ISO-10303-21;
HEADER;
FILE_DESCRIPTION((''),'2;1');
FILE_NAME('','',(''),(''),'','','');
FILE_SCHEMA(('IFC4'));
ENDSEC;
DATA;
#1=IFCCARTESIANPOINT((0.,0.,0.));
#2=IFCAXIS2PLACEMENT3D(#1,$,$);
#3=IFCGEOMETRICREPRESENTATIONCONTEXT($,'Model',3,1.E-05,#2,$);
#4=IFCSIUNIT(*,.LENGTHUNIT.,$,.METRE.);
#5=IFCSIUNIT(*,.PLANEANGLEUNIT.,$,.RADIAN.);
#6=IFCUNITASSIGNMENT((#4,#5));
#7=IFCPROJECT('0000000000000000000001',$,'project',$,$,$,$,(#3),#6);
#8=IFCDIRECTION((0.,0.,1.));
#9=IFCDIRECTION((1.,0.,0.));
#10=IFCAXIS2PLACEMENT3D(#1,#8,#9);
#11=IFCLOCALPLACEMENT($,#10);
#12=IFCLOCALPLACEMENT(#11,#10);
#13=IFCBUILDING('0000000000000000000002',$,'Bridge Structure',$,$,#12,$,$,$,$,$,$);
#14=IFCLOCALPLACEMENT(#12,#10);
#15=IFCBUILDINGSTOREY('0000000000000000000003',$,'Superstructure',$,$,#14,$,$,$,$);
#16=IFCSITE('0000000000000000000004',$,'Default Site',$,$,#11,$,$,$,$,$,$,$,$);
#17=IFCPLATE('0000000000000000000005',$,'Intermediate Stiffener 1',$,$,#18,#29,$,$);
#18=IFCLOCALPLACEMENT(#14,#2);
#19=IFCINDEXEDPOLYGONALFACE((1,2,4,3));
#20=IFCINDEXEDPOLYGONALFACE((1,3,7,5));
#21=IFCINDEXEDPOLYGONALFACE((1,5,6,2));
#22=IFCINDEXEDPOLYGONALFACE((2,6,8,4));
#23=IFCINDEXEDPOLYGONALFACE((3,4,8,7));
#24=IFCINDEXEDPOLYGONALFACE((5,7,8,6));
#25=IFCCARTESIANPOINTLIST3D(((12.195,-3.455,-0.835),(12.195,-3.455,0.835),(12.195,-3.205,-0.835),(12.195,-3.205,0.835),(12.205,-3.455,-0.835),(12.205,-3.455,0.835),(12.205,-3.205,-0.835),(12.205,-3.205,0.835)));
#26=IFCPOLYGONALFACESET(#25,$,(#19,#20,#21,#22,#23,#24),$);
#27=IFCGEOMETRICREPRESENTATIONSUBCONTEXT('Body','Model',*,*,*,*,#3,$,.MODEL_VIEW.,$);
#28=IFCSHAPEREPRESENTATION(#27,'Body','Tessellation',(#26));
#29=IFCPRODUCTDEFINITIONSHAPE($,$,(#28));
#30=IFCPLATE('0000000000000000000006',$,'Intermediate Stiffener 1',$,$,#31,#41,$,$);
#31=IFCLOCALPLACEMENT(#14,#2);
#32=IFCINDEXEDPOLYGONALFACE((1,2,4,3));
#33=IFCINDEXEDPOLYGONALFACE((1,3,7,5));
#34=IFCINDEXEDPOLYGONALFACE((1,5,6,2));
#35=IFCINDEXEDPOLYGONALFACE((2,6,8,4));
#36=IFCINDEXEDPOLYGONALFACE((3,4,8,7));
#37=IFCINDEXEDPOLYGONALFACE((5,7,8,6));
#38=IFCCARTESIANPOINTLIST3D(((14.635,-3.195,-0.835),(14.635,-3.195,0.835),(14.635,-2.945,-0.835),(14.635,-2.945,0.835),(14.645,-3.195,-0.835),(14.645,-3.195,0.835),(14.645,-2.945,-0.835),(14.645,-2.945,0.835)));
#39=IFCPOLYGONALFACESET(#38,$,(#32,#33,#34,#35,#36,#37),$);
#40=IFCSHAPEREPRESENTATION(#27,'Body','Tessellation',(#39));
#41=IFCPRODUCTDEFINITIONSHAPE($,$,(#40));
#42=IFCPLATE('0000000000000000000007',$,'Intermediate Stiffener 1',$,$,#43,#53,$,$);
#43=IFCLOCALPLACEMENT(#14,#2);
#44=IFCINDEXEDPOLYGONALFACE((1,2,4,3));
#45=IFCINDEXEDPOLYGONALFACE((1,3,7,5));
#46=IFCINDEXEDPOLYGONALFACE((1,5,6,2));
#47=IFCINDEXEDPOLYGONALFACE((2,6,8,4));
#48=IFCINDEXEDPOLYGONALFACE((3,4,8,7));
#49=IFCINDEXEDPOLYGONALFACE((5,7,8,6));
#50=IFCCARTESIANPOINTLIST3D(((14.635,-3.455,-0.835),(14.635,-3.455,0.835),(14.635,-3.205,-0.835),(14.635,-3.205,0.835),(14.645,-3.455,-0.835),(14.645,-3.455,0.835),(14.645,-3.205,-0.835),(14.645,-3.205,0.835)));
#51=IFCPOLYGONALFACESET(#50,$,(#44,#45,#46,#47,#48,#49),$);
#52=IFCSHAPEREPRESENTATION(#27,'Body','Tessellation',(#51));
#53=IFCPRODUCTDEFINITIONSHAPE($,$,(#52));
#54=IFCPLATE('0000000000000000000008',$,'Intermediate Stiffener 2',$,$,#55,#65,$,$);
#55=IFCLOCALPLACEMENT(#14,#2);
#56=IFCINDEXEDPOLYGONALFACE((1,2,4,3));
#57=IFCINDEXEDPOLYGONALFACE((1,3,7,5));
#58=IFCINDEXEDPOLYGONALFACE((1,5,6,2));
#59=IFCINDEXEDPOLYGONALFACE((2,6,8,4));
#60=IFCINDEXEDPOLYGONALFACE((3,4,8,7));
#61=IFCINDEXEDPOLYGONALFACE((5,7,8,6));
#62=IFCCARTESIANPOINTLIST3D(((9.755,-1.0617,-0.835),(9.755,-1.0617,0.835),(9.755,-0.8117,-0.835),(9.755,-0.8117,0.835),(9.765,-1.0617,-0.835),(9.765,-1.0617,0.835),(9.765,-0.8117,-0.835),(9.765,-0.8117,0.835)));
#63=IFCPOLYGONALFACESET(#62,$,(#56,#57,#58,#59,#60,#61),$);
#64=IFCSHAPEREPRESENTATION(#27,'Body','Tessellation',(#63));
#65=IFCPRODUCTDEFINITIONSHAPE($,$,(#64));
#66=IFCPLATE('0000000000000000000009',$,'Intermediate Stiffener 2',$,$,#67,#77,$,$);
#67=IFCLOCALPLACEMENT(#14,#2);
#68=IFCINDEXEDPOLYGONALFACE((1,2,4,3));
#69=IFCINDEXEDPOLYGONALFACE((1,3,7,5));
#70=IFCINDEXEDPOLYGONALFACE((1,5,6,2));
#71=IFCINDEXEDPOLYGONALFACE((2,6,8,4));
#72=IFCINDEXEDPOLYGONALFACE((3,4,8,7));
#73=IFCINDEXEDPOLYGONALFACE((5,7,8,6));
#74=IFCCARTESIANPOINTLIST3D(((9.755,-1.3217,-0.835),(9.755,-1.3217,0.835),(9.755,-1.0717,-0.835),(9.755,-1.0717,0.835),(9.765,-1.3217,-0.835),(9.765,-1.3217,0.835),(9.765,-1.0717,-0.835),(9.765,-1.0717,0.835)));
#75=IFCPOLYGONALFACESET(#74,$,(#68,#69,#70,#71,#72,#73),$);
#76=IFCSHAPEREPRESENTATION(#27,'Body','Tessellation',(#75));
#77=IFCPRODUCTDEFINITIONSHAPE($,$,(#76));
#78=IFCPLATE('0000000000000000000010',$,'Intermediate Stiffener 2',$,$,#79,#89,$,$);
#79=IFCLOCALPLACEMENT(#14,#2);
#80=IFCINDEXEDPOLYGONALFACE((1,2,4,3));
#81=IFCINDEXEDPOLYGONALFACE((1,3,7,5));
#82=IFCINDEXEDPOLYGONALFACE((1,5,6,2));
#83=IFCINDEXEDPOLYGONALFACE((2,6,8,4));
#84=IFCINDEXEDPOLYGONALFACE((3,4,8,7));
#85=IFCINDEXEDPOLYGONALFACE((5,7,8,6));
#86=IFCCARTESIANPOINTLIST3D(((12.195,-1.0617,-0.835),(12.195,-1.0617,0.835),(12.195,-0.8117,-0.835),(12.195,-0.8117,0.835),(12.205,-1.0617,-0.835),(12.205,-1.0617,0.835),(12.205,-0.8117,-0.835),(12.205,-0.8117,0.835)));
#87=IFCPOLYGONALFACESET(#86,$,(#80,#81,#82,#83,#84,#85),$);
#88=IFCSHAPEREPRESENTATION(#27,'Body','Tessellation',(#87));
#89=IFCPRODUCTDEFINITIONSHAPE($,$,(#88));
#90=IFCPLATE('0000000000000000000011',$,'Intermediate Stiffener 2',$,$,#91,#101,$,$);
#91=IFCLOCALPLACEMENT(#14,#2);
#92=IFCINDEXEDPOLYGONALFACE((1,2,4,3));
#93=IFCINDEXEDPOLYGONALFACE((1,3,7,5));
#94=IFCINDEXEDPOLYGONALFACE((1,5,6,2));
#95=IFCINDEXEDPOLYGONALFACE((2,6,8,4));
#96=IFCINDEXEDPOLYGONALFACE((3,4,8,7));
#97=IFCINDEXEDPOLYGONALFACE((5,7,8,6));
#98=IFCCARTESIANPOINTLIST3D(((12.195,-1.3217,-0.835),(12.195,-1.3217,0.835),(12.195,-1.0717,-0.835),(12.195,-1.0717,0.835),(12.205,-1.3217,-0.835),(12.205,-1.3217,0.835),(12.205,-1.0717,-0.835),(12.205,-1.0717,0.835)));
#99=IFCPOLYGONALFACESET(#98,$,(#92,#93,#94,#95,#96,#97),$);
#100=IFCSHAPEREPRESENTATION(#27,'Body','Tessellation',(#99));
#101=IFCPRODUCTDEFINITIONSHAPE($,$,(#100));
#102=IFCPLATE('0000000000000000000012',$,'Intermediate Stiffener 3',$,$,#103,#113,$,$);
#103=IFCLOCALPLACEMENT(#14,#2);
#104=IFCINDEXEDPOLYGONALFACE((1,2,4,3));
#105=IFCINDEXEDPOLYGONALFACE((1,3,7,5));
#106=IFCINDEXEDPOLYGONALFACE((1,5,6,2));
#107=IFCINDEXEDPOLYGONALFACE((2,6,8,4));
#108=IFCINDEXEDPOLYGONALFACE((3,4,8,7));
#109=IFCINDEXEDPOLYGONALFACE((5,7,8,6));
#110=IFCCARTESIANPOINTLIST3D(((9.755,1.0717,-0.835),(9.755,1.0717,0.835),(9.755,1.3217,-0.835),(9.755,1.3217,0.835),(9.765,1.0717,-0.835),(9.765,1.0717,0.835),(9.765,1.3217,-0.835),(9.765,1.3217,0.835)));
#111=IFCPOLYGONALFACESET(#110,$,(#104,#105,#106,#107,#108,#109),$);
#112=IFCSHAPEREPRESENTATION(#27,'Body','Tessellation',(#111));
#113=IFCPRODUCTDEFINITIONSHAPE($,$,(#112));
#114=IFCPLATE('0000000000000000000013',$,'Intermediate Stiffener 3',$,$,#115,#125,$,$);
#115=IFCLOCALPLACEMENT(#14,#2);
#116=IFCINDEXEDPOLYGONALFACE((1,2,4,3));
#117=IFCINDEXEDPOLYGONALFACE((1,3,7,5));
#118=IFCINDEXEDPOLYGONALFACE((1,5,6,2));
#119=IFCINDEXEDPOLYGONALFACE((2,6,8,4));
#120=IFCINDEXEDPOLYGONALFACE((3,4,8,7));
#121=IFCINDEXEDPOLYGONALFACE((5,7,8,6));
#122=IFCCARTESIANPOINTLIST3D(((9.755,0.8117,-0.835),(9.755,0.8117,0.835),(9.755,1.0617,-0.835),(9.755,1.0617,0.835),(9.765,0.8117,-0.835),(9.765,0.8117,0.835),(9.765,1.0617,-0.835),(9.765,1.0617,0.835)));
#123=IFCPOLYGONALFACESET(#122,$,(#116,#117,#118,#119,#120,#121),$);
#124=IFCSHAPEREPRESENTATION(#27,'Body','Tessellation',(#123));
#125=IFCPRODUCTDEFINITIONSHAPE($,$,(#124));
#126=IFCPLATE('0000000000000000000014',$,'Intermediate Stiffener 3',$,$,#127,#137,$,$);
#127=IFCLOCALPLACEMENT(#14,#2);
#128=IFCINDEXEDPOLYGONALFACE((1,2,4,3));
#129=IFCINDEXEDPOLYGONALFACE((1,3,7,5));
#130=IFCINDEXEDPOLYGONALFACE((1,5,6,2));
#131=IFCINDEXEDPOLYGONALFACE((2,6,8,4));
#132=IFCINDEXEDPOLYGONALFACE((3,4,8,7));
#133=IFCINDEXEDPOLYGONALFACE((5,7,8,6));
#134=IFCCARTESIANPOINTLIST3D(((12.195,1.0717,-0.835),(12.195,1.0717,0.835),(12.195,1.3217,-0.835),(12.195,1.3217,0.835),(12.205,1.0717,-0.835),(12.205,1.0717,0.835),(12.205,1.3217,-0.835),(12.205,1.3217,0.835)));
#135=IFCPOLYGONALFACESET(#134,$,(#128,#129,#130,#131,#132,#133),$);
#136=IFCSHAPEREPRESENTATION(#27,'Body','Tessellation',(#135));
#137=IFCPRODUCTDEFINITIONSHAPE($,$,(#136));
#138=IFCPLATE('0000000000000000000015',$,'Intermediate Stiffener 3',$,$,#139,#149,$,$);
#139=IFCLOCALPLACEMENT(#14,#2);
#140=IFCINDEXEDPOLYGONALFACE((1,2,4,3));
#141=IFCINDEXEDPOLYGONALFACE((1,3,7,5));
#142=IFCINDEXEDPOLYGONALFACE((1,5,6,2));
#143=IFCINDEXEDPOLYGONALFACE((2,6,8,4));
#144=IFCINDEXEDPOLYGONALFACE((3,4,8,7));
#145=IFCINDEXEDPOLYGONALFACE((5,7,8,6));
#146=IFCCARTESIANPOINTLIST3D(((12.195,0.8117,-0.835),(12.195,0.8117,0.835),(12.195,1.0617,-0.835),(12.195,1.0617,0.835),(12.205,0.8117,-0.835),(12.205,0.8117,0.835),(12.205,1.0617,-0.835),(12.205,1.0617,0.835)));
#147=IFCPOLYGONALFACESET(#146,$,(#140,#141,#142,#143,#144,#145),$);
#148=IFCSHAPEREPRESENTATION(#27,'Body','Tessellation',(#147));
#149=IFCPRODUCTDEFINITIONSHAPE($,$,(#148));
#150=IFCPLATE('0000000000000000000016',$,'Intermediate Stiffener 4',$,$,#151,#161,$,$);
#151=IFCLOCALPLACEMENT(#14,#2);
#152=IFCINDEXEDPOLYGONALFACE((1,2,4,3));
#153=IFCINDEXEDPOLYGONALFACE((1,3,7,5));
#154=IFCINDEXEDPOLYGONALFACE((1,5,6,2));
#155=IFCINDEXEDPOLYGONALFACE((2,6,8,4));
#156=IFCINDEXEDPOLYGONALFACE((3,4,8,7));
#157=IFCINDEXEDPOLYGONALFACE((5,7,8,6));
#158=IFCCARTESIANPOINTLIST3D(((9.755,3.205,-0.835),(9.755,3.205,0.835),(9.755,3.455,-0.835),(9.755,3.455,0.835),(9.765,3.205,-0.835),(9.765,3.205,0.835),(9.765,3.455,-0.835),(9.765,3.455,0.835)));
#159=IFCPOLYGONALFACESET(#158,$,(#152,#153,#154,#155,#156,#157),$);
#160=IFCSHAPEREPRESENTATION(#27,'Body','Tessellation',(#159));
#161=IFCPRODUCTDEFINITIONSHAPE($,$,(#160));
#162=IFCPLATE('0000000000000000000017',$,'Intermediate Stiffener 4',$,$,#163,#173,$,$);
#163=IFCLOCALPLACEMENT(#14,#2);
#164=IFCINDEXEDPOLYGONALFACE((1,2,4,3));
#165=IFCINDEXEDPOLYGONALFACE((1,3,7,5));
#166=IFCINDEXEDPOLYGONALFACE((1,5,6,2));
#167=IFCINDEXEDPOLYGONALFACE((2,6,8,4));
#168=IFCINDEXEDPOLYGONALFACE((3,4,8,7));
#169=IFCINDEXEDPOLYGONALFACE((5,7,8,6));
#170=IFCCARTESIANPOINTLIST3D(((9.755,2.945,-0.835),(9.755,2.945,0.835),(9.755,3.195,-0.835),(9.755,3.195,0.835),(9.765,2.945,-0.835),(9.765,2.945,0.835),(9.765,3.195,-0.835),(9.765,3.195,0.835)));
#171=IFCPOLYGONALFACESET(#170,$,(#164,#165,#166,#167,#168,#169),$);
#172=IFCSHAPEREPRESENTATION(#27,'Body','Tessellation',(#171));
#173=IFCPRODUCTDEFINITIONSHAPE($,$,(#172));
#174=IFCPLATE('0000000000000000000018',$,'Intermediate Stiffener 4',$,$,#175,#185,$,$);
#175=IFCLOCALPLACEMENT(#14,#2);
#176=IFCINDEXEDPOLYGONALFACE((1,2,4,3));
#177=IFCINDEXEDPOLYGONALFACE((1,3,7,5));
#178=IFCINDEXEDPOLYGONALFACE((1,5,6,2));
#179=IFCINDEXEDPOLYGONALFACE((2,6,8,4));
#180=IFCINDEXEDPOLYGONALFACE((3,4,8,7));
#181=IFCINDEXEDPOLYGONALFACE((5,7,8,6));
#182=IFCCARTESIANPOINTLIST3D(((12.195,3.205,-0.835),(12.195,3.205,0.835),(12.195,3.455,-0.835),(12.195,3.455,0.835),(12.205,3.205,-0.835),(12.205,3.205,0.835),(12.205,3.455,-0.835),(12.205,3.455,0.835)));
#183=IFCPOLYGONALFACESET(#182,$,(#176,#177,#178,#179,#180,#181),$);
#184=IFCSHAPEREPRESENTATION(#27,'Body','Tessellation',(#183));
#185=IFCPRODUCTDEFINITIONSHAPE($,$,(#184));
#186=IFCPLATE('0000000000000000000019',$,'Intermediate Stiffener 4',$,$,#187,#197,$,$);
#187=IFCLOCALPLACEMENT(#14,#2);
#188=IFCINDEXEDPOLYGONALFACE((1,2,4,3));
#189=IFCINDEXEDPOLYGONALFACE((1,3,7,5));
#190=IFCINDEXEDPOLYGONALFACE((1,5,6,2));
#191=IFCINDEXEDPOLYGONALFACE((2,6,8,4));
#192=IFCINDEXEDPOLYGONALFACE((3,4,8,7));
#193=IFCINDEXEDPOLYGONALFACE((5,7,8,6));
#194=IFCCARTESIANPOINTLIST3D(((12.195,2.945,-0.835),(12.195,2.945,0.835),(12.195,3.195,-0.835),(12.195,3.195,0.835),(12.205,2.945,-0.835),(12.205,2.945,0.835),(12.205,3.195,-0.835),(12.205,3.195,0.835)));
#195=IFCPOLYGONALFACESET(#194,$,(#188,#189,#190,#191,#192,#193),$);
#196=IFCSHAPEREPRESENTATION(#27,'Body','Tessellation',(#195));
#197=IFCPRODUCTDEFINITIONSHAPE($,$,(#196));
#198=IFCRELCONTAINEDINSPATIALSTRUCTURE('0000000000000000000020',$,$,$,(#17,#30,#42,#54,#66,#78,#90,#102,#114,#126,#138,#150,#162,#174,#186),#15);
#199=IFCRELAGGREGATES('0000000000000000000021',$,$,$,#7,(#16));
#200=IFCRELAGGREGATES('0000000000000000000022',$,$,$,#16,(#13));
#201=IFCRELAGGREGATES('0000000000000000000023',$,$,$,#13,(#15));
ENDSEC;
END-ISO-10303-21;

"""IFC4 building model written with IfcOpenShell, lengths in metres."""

from ifc_helpers import new_model, si_unit, frame, origin, origin_with_axes, origin_2d_with_axis, place, context, subcontext, project, spatial, rectangle, extrude, element, save


model = new_model("IFC4")

# Units and contexts
model_context = context("Model", 3, precision=1e-05, world=origin())
body_context = subcontext(model_context, "Body", "Model", "MODEL_VIEW")
ifc_project = project(units=[si_unit("LENGTHUNIT", "METRE"), si_unit("PLANEANGLEUNIT", "RADIAN")], contexts=[model_context])

# Site, building, storey
site_placement = place(None, origin_with_axes())
site = spatial("IfcSite", under=ifc_project, at=site_placement, Name="Default Site")
building_placement = place(site_placement, origin_with_axes())
building = spatial("IfcBuilding", under=site, at=building_placement, Name="Bridge Structure")
storey_placement = place(building_placement, origin_with_axes())
storey = spatial("IfcBuildingStorey", under=building, at=storey_placement, Name="Superstructure")

# Plates
for number, where, z_axis, x_axis, name in (
    (1, (12.2, -3.33, -0.835), (0.0, 0.0, 1.0), (1.0, 0.0, 0.0), "Intermediate Stiffener 1"),
    (2, (14.64, -3.07, -0.835), (0.0, 0.0, 1.0), (1.0, 0.0, 0.0), "Intermediate Stiffener 1"),
    (3, (14.64, -3.33, -0.835), (0.0, 0.0, 1.0), (1.0, 0.0, 0.0), "Intermediate Stiffener 1"),
    (4, (9.76, -0.9367, -0.835), (0.0, 0.0, 1.0), (1.0, 0.0, 0.0), "Intermediate Stiffener 2"),
    (5, (9.76, -1.1967, -0.835), (0.0, 0.0, 1.0), (1.0, 0.0, 0.0), "Intermediate Stiffener 2"),
    (6, (12.2, -0.9367, -0.835), (0.0, 0.0, 1.0), (1.0, 0.0, 0.0), "Intermediate Stiffener 2"),
    (7, (12.2, -1.1967, -0.835), (0.0, 0.0, 1.0), (1.0, 0.0, 0.0), "Intermediate Stiffener 2"),
    (8, (9.76, 1.1967, -0.835), (0.0, 0.0, 1.0), (1.0, 0.0, 0.0), "Intermediate Stiffener 3"),
    (9, (9.76, 0.9367, -0.835), (0.0, 0.0, 1.0), (1.0, 0.0, 0.0), "Intermediate Stiffener 3"),
    (10, (12.2, 1.1967, -0.835), (0.0, 0.0, 1.0), (1.0, 0.0, 0.0), "Intermediate Stiffener 3"),
    (11, (12.2, 0.9367, -0.835), (0.0, 0.0, 1.0), (1.0, 0.0, 0.0), "Intermediate Stiffener 3"),
    (12, (9.76, 3.33, -0.835), (0.0, 0.0, 1.0), (1.0, 0.0, 0.0), "Intermediate Stiffener 4"),
    (13, (9.76, 3.07, -0.835), (0.0, 0.0, 1.0), (1.0, 0.0, 0.0), "Intermediate Stiffener 4"),
    (14, (12.2, 3.33, -0.835), (0.0, 0.0, 1.0), (1.0, 0.0, 0.0), "Intermediate Stiffener 4"),
    (15, (12.2, 3.07, -0.835), (0.0, 0.0, 1.0), (1.0, 0.0, 0.0), "Intermediate Stiffener 4"),
):
    element("IfcPlate", number, at=place(storey_placement, frame(where, z_axis=z_axis, x_axis=x_axis)), inside=storey, Name=name, context=body_context, shape_type="SweptSolid", body=[
        extrude(rectangle(XDim=0.01, YDim=0.25, at=origin_2d_with_axis()), origin_with_axes(), (0.0, 0.0, 1.0), 1.67),
    ])

save(model, "model.ifc")
